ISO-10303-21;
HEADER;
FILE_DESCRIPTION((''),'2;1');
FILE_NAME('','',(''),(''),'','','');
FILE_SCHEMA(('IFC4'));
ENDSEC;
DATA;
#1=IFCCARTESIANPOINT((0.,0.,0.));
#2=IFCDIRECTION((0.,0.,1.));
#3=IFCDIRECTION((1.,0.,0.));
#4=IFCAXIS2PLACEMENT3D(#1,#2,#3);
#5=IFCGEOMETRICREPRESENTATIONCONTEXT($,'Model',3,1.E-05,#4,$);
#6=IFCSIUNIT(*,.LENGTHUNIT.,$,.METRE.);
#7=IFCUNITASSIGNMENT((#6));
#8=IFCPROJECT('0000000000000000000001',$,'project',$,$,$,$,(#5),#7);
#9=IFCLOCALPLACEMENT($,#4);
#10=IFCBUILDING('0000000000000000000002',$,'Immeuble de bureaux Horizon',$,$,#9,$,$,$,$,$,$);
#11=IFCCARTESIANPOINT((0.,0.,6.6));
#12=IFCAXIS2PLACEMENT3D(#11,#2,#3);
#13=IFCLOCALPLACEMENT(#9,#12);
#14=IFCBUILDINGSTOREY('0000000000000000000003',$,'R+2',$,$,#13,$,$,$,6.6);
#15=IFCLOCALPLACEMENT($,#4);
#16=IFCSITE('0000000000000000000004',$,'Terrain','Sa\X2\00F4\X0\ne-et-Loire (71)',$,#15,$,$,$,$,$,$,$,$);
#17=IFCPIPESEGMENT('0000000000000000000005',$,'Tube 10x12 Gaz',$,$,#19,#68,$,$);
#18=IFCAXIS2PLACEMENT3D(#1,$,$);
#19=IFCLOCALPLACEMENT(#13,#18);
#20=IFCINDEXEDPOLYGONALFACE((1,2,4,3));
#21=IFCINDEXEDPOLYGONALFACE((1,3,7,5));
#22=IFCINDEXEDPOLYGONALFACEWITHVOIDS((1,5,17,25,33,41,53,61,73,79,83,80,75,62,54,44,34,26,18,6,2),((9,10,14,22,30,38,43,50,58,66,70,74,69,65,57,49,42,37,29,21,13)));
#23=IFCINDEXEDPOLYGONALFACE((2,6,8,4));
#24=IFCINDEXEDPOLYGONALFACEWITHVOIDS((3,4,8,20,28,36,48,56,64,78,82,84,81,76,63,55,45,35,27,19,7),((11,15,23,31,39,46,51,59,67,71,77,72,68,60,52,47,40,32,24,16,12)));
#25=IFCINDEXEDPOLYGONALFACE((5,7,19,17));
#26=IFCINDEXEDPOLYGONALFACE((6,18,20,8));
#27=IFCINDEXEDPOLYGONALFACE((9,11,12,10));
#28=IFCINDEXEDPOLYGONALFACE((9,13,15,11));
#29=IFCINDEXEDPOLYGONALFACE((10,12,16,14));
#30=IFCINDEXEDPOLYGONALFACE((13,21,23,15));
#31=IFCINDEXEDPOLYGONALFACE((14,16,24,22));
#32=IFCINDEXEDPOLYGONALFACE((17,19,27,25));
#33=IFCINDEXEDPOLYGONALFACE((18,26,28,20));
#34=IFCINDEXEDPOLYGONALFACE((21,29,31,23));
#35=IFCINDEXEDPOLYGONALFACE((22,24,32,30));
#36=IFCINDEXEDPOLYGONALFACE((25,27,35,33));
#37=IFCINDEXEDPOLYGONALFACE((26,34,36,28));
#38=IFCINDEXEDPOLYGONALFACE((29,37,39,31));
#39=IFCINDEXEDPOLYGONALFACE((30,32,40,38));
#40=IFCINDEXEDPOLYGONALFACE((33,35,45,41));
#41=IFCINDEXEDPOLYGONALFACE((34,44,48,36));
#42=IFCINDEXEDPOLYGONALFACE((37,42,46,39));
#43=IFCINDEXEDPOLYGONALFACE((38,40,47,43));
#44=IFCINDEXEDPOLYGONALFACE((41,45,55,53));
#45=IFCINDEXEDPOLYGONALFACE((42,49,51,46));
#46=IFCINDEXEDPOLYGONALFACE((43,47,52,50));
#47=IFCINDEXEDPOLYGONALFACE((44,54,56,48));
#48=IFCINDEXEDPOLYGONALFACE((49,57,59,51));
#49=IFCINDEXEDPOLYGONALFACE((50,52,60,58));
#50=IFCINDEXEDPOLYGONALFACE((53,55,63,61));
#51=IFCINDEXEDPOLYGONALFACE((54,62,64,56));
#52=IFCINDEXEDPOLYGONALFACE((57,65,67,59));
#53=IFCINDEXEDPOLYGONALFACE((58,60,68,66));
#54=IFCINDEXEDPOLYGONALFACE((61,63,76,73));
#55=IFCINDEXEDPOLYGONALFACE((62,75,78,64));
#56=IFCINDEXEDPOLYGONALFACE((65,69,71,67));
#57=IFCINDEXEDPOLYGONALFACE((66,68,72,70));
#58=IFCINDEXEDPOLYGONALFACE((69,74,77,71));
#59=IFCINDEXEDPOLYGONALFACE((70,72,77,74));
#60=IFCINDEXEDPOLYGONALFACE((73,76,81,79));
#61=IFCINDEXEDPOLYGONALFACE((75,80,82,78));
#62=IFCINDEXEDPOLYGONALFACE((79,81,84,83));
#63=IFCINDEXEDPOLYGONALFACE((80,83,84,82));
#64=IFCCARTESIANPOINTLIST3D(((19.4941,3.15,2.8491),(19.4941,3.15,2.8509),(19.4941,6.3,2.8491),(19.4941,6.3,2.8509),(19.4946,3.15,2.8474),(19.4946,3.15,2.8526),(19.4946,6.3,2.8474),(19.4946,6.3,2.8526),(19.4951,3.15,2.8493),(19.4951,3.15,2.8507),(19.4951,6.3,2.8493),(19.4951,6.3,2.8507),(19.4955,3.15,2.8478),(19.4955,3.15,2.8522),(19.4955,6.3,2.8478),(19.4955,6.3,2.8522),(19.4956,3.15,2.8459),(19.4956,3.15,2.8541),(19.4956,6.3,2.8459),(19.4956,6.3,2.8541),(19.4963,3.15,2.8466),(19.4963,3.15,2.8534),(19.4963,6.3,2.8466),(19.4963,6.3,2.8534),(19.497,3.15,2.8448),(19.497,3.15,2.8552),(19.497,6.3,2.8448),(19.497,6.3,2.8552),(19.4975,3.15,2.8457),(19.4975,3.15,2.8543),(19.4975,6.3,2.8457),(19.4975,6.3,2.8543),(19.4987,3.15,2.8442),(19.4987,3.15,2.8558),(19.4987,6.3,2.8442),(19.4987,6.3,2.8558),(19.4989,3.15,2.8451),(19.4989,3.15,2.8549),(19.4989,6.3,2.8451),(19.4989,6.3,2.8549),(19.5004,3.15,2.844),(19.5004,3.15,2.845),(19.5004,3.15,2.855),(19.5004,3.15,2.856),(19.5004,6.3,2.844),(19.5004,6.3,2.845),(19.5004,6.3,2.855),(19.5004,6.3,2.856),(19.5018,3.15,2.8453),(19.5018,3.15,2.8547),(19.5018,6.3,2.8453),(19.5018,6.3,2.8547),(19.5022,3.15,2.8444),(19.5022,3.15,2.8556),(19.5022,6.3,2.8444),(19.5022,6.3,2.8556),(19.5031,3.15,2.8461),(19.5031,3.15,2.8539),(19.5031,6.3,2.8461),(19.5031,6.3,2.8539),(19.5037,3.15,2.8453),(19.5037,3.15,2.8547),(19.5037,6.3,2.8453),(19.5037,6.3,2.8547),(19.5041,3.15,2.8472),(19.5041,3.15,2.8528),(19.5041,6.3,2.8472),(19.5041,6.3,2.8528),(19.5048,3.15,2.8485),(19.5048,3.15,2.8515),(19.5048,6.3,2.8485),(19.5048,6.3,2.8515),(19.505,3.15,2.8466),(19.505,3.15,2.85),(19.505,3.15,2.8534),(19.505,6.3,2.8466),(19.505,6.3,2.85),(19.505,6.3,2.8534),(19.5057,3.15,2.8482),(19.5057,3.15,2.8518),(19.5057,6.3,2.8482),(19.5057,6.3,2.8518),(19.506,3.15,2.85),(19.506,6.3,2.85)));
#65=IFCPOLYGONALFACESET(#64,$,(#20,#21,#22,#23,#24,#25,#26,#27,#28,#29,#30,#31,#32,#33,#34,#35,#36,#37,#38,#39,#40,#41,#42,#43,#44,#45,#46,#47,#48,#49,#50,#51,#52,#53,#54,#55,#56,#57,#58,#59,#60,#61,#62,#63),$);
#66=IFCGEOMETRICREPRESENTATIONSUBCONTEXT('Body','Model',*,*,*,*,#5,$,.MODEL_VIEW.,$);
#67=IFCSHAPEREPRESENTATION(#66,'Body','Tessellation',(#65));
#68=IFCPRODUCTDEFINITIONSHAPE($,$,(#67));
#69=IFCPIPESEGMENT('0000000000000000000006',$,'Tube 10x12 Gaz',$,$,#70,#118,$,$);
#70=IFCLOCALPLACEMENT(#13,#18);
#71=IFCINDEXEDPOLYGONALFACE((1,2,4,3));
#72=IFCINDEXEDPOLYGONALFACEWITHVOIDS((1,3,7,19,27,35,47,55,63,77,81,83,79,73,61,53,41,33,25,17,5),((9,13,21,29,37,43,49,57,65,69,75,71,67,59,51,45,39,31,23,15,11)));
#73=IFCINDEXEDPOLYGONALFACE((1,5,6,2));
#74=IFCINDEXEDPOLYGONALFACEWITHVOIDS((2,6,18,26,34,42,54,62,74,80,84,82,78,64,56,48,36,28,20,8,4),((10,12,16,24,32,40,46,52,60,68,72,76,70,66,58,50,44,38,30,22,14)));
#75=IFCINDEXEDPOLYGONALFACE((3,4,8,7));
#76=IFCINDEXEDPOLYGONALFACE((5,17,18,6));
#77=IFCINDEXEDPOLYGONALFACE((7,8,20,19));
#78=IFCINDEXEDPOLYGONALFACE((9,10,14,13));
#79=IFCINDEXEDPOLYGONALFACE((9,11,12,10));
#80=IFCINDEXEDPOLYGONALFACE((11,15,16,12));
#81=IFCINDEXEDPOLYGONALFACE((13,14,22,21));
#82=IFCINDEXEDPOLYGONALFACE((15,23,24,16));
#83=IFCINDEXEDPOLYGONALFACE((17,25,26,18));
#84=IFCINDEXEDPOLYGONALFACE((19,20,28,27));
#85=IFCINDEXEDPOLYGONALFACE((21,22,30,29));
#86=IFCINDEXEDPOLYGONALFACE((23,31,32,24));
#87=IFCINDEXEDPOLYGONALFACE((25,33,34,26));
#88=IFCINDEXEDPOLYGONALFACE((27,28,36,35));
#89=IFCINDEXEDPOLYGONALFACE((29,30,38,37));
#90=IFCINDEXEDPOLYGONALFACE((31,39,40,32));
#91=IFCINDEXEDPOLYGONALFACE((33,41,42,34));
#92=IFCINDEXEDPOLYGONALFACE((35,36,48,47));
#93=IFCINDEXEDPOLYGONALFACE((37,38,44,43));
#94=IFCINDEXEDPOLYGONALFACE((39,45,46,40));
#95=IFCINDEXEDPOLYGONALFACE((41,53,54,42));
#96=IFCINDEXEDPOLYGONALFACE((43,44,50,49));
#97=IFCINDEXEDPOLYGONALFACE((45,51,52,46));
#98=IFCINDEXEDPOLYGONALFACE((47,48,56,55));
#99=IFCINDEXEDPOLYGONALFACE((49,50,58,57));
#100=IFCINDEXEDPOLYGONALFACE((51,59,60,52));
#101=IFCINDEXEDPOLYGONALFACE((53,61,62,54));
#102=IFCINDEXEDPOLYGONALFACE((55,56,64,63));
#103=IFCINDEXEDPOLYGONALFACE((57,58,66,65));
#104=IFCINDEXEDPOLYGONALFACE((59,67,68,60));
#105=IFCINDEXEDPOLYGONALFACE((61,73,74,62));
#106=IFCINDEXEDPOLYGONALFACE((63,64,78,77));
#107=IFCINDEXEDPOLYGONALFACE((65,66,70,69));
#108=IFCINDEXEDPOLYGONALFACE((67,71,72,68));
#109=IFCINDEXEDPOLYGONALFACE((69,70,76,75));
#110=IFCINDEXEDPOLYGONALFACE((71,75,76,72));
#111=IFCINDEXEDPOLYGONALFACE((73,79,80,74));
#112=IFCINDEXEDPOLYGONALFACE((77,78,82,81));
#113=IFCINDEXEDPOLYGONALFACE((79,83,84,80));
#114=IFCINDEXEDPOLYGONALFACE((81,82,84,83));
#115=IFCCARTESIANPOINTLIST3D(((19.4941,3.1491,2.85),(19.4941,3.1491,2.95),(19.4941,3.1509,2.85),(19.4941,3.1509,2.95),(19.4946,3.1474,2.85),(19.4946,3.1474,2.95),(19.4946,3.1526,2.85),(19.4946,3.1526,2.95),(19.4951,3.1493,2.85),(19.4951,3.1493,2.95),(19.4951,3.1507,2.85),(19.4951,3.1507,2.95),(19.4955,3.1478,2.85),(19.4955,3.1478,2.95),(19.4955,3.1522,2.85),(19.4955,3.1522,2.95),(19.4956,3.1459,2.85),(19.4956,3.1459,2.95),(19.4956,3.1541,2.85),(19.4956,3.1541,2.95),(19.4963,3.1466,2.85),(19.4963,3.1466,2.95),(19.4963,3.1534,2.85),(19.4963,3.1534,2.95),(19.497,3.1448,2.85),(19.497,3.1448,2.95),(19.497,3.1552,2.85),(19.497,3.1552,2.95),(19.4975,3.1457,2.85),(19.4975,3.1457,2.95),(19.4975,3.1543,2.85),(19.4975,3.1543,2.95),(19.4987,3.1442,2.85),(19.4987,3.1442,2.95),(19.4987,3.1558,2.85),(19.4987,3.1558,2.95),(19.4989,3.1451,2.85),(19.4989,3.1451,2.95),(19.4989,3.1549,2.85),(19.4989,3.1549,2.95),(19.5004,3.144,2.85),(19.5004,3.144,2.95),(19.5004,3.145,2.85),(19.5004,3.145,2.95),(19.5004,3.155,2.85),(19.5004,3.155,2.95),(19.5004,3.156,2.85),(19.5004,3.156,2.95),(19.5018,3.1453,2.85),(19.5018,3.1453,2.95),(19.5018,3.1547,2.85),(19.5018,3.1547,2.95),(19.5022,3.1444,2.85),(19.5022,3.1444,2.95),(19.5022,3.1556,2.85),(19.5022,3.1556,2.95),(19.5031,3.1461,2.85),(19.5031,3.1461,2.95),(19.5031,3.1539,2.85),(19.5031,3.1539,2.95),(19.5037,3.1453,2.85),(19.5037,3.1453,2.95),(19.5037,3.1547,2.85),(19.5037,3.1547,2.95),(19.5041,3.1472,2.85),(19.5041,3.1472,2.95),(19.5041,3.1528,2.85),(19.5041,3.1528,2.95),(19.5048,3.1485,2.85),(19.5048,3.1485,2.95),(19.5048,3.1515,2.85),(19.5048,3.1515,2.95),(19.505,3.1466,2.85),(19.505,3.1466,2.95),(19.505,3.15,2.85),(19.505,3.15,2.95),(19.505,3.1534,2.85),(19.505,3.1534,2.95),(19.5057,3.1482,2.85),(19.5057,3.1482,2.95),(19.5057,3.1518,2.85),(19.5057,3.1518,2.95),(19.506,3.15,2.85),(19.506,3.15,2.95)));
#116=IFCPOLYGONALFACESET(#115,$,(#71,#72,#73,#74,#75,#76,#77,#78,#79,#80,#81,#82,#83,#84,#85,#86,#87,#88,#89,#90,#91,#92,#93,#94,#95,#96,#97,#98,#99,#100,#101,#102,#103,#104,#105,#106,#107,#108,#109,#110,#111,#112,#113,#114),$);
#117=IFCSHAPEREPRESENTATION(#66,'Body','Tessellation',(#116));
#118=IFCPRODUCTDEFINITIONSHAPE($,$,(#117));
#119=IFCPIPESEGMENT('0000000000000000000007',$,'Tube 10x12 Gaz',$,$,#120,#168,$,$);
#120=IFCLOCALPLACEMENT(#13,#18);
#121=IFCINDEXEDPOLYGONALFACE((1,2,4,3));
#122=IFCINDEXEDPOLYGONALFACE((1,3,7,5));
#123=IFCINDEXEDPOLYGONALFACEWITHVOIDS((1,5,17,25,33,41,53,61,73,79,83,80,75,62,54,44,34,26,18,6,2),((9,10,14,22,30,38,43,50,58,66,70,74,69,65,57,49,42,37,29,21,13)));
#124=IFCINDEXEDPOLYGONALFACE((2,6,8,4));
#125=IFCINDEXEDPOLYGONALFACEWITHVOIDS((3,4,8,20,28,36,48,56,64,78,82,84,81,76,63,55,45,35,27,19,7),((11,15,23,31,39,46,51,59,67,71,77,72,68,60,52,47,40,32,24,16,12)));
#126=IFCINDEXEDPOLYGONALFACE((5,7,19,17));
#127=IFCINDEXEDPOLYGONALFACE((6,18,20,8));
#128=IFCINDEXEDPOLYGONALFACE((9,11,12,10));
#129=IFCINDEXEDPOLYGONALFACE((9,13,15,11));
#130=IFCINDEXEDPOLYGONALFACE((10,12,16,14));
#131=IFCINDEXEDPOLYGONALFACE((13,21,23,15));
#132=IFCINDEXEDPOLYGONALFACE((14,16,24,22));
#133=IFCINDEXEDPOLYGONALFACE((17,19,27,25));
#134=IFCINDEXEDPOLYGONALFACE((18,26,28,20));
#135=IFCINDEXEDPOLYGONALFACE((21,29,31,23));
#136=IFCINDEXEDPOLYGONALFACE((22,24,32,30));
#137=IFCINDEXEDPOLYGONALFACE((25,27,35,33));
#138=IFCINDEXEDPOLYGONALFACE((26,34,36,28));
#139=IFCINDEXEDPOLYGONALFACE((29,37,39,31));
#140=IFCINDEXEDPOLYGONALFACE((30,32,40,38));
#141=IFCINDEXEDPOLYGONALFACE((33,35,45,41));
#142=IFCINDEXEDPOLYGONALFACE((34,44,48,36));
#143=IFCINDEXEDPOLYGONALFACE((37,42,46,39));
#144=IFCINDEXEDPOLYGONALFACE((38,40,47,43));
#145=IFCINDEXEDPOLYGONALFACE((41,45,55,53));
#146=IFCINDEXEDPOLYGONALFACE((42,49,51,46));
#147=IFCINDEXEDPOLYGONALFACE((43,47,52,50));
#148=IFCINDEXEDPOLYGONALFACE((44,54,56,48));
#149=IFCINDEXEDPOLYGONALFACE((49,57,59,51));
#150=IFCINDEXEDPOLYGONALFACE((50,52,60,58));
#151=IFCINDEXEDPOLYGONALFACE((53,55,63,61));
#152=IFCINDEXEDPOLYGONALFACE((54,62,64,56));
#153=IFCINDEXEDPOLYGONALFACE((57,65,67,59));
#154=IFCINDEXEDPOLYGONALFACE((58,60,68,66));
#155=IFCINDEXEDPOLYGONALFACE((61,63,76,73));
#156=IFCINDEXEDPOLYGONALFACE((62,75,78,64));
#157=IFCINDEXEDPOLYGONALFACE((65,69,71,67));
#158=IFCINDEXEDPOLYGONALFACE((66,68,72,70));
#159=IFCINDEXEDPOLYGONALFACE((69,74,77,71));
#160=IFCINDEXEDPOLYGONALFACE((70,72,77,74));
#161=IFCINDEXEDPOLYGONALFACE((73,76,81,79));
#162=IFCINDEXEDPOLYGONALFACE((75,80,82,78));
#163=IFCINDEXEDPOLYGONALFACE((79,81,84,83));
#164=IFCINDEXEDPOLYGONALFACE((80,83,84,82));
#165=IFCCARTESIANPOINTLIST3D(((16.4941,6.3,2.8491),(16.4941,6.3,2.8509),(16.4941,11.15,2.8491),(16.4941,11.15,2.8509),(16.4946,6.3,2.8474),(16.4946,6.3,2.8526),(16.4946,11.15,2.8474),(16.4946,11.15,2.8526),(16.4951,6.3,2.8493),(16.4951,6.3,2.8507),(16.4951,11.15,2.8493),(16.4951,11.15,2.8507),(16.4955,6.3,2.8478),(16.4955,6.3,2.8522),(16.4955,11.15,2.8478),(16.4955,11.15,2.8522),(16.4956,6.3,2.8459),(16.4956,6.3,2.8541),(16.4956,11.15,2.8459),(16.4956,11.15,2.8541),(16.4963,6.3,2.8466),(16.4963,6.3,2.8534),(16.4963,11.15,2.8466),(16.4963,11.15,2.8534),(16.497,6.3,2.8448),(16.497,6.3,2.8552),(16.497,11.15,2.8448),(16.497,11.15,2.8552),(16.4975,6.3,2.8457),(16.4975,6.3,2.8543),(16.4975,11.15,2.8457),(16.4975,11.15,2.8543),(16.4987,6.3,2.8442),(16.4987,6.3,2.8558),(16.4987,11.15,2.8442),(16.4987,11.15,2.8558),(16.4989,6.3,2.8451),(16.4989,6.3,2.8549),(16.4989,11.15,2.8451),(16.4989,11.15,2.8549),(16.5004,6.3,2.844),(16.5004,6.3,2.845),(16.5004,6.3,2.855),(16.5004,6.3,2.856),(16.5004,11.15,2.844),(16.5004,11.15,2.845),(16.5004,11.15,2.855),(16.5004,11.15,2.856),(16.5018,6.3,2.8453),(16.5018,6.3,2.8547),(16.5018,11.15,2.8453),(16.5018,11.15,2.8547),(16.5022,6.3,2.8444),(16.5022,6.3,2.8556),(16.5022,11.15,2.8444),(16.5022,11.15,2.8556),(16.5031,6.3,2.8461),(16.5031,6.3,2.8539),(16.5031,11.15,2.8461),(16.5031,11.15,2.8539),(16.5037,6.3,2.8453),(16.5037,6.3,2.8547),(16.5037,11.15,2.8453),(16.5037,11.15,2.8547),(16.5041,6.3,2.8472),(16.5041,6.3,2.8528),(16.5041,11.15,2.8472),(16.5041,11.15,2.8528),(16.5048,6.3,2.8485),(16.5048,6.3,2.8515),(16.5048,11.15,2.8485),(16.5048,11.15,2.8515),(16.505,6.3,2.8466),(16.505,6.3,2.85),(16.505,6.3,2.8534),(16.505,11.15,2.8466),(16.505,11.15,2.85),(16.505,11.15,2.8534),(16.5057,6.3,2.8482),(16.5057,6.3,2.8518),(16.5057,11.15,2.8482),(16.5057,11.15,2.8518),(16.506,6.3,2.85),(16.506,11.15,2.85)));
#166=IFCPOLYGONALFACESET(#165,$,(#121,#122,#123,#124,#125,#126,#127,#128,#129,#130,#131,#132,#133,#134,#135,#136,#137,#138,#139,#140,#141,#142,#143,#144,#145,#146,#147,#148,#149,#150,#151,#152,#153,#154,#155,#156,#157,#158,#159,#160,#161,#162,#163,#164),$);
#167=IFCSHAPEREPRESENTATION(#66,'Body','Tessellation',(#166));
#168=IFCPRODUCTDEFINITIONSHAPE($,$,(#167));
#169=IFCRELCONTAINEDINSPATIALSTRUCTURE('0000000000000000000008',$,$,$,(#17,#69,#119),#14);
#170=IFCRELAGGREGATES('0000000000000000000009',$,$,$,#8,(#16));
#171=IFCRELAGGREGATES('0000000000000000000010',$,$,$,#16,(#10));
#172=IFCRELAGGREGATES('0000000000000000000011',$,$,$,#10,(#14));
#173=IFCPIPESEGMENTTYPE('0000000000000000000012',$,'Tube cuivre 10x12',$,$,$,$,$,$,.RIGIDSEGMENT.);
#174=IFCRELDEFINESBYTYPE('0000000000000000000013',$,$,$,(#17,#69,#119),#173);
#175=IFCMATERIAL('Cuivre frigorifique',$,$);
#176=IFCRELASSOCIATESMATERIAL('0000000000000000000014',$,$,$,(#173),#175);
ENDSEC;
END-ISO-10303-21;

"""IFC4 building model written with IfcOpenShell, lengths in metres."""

from ifc_helpers import new_model, si_unit, frame, origin_with_axes, place, context, subcontext, project, spatial, hollow_circle, extrude, material, type_object, element, save


model = new_model("IFC4")

# Units and contexts
model_context = context("Model", 3, precision=1e-05, world=origin_with_axes())
body_context = subcontext(model_context, "Body", "Model", "MODEL_VIEW")
ifc_project = project(units=[si_unit("LENGTHUNIT", "METRE")], contexts=[model_context])

# Site, building, storey
site_placement = place(None, origin_with_axes())
site = spatial("IfcSite", under=ifc_project, at=site_placement, Name="Terrain", Description="Saône-et-Loire (71)")
building_placement = place(None, origin_with_axes())
building = spatial("IfcBuilding", under=site, at=building_placement, Name="Immeuble de bureaux Horizon")
storey_placement = place(building_placement, frame((0.0, 0.0, 6.6), z_axis=(0.0, 0.0, 1.0), x_axis=(1.0, 0.0, 0.0)))
storey = spatial("IfcBuildingStorey", under=building, at=storey_placement, Name="R+2", Elevation=6.6)

# Pipe segments
ifc_material_1 = material(Name="Cuivre frigorifique")
pipe_segment_type_1 = type_object("IfcPipeSegmentType", Name="Tube cuivre 10x12", PredefinedType="RIGIDSEGMENT", material=ifc_material_1)
pipe_segment_1_placement = place(storey_placement, frame((19.5, 6.3, 2.85), z_axis=(0.0, -1.0, 0.0), x_axis=(1.0, 0.0, 0.0)))
element("IfcPipeSegment", 1, at=pipe_segment_1_placement, inside=storey, type_object=pipe_segment_type_1, Name="Tube 10x12 Gaz", context=body_context, shape_type="SweptSolid", body=[
    extrude(hollow_circle(Radius=0.006, WallThickness=0.001), origin_with_axes(), (0.0, 0.0, 1.0), 3.15),
])
pipe_segment_2_placement = place(storey_placement, frame((19.5, 3.15, 2.85), z_axis=(0.0, 0.0, 1.0), x_axis=(1.0, 0.0, 0.0)))
element("IfcPipeSegment", 2, at=pipe_segment_2_placement, inside=storey, type_object=pipe_segment_type_1, Name="Tube 10x12 Gaz", context=body_context, shape_type="SweptSolid", body=[
    extrude(hollow_circle(Radius=0.006, WallThickness=0.001), origin_with_axes(), (0.0, 0.0, 1.0), 0.1),
])
for number, where, z_axis, x_axis, name in (
    (3, (16.5, 6.3, 2.85), (0.0, 1.0, 0.0), (1.0, 0.0, 0.0), "Tube 10x12 Gaz"),
):
    element("IfcPipeSegment", number, at=place(storey_placement, frame(where, z_axis=z_axis, x_axis=x_axis)), inside=storey, type_object=pipe_segment_type_1, Name=name, context=body_context, shape_type="SweptSolid", body=[
        extrude(hollow_circle(Radius=0.006, WallThickness=0.001), origin_with_axes(), (0.0, 0.0, 1.0), 4.85),
    ])

save(model, "model.ifc")
